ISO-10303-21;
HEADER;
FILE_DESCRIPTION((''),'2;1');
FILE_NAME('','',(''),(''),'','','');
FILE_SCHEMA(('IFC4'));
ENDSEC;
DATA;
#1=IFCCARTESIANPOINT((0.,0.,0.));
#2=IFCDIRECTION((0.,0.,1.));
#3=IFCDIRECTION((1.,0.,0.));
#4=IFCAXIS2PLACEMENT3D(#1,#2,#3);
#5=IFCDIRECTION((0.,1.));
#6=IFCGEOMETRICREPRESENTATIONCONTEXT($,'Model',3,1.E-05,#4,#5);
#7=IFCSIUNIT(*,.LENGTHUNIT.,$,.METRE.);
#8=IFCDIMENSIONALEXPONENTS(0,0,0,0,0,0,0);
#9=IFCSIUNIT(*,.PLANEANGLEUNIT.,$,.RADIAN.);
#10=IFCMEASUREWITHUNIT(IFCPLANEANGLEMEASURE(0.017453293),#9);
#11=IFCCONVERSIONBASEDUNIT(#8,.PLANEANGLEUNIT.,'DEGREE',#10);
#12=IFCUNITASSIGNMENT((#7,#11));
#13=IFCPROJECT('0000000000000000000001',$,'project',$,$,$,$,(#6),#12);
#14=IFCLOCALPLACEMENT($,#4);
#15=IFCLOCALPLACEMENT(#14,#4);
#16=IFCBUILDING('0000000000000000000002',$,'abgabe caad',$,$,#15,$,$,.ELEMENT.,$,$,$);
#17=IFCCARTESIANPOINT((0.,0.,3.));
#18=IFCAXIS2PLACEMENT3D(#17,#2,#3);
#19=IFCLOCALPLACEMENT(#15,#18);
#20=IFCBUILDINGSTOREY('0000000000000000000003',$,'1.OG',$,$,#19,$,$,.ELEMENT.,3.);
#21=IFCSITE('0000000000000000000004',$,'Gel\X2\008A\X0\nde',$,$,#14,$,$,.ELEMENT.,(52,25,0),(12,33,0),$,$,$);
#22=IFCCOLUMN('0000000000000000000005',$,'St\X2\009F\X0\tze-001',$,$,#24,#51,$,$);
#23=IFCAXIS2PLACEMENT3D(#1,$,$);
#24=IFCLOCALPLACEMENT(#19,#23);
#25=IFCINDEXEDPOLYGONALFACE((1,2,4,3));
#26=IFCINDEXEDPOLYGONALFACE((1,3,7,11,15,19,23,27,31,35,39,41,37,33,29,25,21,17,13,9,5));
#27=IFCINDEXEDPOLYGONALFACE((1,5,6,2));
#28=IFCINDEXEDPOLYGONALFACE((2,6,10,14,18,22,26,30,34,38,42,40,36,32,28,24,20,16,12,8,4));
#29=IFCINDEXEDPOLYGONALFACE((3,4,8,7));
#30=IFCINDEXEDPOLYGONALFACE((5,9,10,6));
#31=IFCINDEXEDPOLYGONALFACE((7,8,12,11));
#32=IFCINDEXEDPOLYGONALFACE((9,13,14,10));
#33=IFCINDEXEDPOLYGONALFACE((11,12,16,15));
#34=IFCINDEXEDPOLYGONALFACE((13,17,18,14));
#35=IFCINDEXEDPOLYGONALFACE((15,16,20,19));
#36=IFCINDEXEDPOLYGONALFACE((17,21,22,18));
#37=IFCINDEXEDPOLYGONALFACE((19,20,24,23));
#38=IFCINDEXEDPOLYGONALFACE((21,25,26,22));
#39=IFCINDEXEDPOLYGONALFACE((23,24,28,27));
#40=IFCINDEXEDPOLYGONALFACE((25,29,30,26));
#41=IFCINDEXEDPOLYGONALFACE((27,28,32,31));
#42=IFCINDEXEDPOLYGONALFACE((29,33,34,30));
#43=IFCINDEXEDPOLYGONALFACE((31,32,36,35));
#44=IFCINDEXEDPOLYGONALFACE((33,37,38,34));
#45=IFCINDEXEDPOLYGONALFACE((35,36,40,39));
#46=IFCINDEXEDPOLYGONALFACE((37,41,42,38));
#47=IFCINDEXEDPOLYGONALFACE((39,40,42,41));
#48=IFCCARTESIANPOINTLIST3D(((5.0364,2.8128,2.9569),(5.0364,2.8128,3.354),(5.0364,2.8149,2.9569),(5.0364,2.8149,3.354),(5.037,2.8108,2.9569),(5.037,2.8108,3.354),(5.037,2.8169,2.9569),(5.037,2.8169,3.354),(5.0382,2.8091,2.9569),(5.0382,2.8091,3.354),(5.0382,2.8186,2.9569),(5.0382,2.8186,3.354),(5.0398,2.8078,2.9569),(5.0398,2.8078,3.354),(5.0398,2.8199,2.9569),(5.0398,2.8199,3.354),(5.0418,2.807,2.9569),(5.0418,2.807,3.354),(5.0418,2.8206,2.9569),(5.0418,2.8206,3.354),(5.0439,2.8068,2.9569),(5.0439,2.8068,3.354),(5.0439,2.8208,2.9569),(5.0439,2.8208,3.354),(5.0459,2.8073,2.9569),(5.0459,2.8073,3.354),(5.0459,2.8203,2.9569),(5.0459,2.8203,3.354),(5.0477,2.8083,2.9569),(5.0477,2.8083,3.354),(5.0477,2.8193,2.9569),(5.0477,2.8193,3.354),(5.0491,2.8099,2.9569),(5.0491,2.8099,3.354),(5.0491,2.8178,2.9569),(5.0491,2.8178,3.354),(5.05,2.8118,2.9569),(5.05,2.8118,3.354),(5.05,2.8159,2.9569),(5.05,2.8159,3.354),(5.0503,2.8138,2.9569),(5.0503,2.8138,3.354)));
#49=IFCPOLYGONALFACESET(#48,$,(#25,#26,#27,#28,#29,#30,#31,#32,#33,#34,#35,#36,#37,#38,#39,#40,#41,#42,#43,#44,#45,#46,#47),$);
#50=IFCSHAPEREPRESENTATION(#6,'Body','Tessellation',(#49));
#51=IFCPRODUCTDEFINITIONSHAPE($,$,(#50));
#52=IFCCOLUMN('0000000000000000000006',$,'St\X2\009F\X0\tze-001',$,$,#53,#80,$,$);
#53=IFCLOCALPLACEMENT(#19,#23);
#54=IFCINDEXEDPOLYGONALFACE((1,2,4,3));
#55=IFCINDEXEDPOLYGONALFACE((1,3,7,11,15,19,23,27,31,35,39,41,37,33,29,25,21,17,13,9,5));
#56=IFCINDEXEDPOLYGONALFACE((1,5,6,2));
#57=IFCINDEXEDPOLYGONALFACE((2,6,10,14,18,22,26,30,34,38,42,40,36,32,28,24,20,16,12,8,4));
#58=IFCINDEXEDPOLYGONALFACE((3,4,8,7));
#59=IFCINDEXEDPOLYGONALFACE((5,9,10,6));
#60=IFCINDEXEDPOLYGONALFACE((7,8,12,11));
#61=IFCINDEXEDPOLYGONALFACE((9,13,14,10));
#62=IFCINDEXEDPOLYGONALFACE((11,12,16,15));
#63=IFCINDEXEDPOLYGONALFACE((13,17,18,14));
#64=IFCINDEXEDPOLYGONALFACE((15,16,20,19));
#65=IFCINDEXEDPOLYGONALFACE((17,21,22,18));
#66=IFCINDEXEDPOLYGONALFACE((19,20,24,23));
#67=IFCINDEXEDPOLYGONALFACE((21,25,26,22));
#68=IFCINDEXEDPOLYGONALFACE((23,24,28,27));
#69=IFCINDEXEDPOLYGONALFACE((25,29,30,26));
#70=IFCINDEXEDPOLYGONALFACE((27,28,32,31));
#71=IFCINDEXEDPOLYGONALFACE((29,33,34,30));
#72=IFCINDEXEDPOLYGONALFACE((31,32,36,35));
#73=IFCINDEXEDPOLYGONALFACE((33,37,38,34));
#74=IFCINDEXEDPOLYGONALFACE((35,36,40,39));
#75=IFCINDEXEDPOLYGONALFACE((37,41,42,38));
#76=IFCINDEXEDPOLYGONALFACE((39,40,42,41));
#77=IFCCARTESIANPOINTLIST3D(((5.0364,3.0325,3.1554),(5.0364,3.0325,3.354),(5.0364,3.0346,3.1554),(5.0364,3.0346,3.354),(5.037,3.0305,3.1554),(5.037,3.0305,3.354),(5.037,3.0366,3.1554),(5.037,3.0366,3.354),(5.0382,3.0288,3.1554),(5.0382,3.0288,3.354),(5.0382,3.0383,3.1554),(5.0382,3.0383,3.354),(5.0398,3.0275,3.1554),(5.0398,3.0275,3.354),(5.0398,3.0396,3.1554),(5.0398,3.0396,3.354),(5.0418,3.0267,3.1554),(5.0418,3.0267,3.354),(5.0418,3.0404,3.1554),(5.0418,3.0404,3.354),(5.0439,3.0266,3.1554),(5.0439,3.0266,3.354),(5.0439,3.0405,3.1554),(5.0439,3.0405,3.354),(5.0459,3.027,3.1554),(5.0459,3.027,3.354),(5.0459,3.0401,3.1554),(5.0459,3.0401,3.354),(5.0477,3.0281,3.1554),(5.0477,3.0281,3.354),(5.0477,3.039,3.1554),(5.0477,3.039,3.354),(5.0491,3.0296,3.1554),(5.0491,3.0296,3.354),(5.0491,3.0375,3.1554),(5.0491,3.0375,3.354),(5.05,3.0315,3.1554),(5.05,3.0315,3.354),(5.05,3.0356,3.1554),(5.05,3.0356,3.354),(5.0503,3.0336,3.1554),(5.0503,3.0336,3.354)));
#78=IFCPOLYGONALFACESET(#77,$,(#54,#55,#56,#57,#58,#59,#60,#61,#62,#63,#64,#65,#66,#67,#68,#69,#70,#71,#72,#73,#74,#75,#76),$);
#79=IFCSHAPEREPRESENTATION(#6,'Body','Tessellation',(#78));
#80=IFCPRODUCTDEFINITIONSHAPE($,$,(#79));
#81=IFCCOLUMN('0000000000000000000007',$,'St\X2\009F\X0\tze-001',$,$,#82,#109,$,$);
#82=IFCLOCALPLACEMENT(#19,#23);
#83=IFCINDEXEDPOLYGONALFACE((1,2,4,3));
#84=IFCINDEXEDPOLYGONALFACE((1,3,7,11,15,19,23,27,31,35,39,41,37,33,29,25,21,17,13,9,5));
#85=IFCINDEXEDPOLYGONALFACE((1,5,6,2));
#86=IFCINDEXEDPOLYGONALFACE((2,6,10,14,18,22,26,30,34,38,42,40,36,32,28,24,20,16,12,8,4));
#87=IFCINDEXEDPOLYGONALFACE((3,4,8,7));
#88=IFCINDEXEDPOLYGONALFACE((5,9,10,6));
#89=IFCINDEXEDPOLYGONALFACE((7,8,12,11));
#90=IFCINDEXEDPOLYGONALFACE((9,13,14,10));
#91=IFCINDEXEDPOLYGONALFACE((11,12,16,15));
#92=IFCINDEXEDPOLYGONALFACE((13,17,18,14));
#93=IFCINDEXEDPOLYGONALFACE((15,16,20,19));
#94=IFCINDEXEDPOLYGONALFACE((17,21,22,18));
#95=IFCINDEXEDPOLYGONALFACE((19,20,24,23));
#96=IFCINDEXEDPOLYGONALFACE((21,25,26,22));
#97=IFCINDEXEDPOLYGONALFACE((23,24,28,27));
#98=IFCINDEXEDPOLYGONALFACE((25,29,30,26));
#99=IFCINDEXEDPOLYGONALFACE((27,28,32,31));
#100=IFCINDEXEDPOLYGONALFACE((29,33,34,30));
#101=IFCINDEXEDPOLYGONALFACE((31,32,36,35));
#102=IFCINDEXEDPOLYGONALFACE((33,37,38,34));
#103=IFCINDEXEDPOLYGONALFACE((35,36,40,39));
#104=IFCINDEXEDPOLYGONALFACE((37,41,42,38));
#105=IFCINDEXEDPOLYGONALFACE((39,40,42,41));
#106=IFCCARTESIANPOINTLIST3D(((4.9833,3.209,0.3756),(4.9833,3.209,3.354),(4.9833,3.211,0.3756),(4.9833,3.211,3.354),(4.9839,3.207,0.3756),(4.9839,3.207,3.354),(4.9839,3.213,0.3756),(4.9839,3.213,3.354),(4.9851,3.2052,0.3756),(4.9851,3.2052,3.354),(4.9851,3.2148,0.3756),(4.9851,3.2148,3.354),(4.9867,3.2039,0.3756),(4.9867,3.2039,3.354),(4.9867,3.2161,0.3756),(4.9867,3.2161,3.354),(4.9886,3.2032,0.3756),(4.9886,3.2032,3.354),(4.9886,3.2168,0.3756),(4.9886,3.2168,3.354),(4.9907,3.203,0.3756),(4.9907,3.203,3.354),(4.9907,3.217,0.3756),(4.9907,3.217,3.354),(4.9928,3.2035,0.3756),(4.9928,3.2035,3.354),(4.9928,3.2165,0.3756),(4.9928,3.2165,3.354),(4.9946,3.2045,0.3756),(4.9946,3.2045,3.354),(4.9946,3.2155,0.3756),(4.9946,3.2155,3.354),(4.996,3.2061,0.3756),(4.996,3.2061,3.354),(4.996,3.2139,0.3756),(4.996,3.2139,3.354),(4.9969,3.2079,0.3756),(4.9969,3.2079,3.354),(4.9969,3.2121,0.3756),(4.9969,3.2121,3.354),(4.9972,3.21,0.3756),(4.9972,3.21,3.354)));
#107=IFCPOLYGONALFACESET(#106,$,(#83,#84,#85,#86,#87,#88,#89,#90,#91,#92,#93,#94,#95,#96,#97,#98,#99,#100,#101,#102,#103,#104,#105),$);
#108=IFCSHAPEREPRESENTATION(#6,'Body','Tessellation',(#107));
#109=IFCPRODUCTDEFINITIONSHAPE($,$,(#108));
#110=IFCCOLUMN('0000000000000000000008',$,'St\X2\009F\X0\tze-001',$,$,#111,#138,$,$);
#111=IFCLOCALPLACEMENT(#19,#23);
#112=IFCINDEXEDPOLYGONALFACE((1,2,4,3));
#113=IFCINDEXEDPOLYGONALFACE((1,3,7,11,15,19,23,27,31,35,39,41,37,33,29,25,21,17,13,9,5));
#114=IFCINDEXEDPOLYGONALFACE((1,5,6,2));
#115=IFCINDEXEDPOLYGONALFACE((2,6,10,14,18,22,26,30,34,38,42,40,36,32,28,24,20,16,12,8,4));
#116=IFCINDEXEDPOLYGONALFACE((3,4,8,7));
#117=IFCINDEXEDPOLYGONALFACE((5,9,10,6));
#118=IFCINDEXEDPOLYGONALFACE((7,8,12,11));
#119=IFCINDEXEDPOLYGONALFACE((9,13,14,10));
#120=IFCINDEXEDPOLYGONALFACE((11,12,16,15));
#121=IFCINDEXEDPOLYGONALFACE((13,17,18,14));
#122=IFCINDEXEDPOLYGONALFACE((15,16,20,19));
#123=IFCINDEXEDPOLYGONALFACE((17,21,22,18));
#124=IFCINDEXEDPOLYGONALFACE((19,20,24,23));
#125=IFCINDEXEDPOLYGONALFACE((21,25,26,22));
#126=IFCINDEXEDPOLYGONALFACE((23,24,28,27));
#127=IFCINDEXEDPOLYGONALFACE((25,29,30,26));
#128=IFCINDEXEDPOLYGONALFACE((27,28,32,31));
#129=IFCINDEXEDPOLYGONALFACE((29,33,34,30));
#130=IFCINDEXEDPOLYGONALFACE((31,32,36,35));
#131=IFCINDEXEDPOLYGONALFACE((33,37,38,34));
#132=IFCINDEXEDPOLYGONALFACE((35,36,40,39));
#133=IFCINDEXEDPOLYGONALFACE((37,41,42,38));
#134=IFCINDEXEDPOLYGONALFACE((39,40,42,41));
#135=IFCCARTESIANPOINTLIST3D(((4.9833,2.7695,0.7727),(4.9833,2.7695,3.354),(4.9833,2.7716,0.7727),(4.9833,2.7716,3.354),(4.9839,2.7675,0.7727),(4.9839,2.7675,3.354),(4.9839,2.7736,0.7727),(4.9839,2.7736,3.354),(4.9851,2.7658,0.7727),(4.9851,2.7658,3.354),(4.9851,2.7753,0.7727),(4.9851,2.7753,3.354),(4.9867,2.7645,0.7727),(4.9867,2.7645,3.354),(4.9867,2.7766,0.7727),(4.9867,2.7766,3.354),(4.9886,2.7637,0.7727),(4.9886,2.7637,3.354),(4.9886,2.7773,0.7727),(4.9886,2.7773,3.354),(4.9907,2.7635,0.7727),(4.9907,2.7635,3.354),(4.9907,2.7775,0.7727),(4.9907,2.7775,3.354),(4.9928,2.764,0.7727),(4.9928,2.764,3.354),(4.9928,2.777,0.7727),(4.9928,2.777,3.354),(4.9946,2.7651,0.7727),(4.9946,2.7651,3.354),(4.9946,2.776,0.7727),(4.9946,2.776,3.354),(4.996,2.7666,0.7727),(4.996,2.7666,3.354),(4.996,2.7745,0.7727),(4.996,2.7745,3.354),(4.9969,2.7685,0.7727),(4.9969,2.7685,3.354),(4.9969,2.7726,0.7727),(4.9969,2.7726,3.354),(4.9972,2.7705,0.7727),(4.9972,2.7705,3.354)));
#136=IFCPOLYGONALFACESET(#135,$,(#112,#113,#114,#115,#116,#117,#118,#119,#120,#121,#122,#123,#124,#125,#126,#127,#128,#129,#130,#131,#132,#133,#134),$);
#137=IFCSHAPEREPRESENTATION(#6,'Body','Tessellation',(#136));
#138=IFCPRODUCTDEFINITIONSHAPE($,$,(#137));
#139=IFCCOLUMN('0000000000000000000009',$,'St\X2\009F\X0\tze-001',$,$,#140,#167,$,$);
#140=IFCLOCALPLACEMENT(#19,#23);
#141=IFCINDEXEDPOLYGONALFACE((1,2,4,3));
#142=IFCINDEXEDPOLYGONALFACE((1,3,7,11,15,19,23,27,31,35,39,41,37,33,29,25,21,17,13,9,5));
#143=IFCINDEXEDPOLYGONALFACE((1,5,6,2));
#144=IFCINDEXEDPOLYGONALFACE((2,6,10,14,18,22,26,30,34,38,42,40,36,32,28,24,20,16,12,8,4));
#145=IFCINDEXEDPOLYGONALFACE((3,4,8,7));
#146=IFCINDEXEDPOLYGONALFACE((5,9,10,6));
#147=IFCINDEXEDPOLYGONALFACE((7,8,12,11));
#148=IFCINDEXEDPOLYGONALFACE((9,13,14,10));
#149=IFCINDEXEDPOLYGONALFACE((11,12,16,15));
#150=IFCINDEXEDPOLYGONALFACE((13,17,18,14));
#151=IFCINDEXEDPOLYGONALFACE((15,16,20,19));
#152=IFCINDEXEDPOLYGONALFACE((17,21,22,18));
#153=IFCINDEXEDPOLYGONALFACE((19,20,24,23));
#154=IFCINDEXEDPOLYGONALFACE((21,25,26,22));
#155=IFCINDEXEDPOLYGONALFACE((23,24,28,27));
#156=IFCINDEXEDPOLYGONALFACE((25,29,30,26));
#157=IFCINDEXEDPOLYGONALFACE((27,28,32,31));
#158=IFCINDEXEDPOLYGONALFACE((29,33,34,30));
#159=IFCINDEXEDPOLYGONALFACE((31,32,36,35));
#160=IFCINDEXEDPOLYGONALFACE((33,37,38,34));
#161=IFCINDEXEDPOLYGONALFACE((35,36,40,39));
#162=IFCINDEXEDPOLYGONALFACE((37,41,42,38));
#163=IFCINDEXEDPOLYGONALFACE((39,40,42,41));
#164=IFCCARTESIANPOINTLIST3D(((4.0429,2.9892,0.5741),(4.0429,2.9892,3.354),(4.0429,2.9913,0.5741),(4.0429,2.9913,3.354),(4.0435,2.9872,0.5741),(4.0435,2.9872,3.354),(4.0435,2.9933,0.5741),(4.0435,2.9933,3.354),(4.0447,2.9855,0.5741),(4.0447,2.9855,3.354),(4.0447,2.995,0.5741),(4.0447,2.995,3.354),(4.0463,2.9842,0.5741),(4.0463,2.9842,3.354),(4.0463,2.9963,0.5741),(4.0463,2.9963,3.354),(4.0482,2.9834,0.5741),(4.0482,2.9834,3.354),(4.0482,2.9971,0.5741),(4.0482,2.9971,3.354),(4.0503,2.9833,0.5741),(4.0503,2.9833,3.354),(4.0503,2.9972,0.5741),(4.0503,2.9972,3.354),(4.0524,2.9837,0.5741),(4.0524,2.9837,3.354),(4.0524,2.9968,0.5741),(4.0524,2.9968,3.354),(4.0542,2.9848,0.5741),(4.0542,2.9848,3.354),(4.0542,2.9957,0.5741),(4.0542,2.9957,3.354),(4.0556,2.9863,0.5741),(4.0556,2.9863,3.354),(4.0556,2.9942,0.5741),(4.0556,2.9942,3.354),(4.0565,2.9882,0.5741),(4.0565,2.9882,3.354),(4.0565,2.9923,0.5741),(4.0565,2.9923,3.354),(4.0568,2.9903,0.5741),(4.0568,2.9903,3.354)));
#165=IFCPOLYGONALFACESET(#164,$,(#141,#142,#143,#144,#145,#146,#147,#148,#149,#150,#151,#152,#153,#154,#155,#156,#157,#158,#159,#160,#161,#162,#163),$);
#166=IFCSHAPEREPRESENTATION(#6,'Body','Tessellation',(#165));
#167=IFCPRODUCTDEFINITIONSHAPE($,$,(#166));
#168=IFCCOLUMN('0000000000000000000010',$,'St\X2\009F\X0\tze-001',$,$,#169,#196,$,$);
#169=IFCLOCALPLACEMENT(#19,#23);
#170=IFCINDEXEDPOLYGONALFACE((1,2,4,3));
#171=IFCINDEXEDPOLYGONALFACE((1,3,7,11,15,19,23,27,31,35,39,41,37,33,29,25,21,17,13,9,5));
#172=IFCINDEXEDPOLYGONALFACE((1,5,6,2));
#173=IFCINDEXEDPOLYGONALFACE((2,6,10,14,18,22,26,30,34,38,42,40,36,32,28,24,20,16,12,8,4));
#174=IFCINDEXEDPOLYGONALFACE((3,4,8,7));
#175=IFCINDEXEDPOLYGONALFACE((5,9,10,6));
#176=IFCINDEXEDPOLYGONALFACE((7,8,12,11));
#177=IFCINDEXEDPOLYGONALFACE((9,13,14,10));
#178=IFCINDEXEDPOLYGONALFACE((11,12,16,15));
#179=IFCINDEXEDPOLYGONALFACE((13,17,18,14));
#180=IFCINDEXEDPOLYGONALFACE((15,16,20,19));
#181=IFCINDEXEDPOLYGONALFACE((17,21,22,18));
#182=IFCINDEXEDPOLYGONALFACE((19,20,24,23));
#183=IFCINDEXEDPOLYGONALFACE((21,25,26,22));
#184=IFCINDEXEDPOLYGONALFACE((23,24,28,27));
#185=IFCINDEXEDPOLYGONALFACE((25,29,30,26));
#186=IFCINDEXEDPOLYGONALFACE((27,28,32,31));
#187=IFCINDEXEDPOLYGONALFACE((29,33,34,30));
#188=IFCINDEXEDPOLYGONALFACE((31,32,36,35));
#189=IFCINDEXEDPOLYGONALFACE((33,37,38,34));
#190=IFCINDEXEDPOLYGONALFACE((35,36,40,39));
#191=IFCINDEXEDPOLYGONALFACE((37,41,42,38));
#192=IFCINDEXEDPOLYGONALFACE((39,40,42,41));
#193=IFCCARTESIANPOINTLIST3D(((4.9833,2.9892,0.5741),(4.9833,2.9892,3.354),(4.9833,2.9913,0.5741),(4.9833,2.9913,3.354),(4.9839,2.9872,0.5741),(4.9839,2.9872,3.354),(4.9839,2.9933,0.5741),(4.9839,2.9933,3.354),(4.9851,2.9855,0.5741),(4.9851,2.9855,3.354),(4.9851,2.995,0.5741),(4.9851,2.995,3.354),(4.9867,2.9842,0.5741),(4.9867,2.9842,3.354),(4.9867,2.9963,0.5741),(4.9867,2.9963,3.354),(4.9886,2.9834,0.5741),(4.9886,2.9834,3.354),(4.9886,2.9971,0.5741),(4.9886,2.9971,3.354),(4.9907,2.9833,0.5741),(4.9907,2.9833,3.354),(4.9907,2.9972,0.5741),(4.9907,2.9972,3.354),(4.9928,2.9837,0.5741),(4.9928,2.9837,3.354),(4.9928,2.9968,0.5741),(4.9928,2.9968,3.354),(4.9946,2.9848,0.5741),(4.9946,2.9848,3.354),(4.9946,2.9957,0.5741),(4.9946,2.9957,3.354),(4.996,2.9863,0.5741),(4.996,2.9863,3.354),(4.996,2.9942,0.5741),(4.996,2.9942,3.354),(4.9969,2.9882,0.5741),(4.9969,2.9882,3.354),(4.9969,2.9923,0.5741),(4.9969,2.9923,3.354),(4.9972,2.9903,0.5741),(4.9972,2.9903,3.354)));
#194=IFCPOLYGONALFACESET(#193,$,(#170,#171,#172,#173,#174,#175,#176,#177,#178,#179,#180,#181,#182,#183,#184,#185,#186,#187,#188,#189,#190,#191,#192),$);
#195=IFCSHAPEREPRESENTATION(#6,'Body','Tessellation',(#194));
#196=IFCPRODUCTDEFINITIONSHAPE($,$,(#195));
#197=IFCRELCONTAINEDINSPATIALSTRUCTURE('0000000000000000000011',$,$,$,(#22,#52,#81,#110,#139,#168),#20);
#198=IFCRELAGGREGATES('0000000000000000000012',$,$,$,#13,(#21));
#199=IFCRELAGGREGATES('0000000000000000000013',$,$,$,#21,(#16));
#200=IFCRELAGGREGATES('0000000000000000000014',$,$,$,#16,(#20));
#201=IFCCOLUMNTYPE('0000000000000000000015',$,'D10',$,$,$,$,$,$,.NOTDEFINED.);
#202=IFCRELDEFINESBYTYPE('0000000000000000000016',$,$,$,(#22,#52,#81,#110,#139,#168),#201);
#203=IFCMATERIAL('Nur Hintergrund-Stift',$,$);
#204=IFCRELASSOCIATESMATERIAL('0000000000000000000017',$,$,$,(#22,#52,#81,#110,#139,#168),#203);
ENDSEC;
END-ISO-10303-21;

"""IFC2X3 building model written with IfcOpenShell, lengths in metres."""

from ifc_helpers import new_model, entity, si_unit, converted_unit, direction, frame, origin_with_axes, origin_2d_with_axis, place, context, project, spatial, circle, extrude, material, type_object, element, save


model = new_model("IFC2X3")

# Units and contexts
model_context = context("Model", 3, precision=1e-05, world=origin_with_axes(), true_north=direction((0.0, 1.0)))
ifc_project = project(units=[si_unit("LENGTHUNIT", "METRE"), converted_unit("PLANEANGLEUNIT", "DEGREE", entity("IfcPlaneAngleMeasure", 0.017453293), si_unit("PLANEANGLEUNIT", "RADIAN"), dimensions=[0, 0, 0, 0, 0, 0, 0])], contexts=[model_context])

# Site, building, storey
site_placement = place(None, origin_with_axes())
site = spatial("IfcSite", under=ifc_project, at=site_placement, Name="Gel\u008ande", CompositionType="ELEMENT", RefLatitude=(52, 25, 0), RefLongitude=(12, 33, 0))
building_placement = place(site_placement, origin_with_axes())
building = spatial("IfcBuilding", under=site, at=building_placement, Name="abgabe caad", CompositionType="ELEMENT")
storey_placement = place(building_placement, frame((0.0, 0.0, 3.0), z_axis=(0.0, 0.0, 1.0), x_axis=(1.0, 0.0, 0.0)))
storey = spatial("IfcBuildingStorey", under=building, at=storey_placement, Name="1.OG", CompositionType="ELEMENT", Elevation=3.0)

# Columns
ifc_material_1 = material(Name="Nur Hintergrund-Stift")
column_type = type_object("IfcColumnType", Name="D10", PredefinedType="NOTDEFINED")
column_1_placement = place(storey_placement, frame((5.0433, 2.8138, 2.9569), z_axis=(0.0, 0.0, 1.0), x_axis=(1.0, 0.0, 0.0)))
element("IfcColumn", 1, at=column_1_placement, inside=storey, type_object=column_type, material=ifc_material_1, Name="St\u009ftze-001", context=model_context, shape_type="SweptSolid", body=[
    extrude(circle(Radius=0.007, at=origin_2d_with_axis()), origin_with_axes(), (0.0, 0.0, 1.0), 0.3971),
])
column_2_placement = place(storey_placement, frame((5.0433, 3.0336, 3.1554), z_axis=(0.0, 0.0, 1.0), x_axis=(1.0, 0.0, 0.0)))
element("IfcColumn", 2, at=column_2_placement, inside=storey, type_object=column_type, material=ifc_material_1, Name="St\u009ftze-001", context=model_context, shape_type="SweptSolid", body=[
    extrude(circle(Radius=0.007, at=origin_2d_with_axis()), origin_with_axes(), (0.0, 0.0, 1.0), 0.1986),
])
column_3_placement = place(storey_placement, frame((4.9902, 3.21, 0.3756), z_axis=(0.0, 0.0, 1.0), x_axis=(1.0, 0.0, 0.0)))
element("IfcColumn", 3, at=column_3_placement, inside=storey, type_object=column_type, material=ifc_material_1, Name="St\u009ftze-001", context=model_context, shape_type="SweptSolid", body=[
    extrude(circle(Radius=0.007, at=origin_2d_with_axis()), origin_with_axes(), (0.0, 0.0, 1.0), 2.9784),
])
column_4_placement = place(storey_placement, frame((4.9902, 2.7705, 0.7727), z_axis=(0.0, 0.0, 1.0), x_axis=(1.0, 0.0, 0.0)))
element("IfcColumn", 4, at=column_4_placement, inside=storey, type_object=column_type, material=ifc_material_1, Name="St\u009ftze-001", context=model_context, shape_type="SweptSolid", body=[
    extrude(circle(Radius=0.007, at=origin_2d_with_axis()), origin_with_axes(), (0.0, 0.0, 1.0), 2.5813),
])
for number, where, z_axis, x_axis, name in (
    (5, (4.0498, 2.9903, 0.5741), (0.0, 0.0, 1.0), (1.0, 0.0, 0.0), "St\u009ftze-001"),
    (6, (4.9902, 2.9903, 0.5741), (0.0, 0.0, 1.0), (1.0, 0.0, 0.0), "St\u009ftze-001"),
):
    element("IfcColumn", number, at=place(storey_placement, frame(where, z_axis=z_axis, x_axis=x_axis)), inside=storey, type_object=column_type, material=ifc_material_1, Name=name, context=model_context, shape_type="SweptSolid", body=[
        extrude(circle(Radius=0.007, at=origin_2d_with_axis()), origin_with_axes(), (0.0, 0.0, 1.0), 2.7799),
    ])

save(model, "model.ifc")
